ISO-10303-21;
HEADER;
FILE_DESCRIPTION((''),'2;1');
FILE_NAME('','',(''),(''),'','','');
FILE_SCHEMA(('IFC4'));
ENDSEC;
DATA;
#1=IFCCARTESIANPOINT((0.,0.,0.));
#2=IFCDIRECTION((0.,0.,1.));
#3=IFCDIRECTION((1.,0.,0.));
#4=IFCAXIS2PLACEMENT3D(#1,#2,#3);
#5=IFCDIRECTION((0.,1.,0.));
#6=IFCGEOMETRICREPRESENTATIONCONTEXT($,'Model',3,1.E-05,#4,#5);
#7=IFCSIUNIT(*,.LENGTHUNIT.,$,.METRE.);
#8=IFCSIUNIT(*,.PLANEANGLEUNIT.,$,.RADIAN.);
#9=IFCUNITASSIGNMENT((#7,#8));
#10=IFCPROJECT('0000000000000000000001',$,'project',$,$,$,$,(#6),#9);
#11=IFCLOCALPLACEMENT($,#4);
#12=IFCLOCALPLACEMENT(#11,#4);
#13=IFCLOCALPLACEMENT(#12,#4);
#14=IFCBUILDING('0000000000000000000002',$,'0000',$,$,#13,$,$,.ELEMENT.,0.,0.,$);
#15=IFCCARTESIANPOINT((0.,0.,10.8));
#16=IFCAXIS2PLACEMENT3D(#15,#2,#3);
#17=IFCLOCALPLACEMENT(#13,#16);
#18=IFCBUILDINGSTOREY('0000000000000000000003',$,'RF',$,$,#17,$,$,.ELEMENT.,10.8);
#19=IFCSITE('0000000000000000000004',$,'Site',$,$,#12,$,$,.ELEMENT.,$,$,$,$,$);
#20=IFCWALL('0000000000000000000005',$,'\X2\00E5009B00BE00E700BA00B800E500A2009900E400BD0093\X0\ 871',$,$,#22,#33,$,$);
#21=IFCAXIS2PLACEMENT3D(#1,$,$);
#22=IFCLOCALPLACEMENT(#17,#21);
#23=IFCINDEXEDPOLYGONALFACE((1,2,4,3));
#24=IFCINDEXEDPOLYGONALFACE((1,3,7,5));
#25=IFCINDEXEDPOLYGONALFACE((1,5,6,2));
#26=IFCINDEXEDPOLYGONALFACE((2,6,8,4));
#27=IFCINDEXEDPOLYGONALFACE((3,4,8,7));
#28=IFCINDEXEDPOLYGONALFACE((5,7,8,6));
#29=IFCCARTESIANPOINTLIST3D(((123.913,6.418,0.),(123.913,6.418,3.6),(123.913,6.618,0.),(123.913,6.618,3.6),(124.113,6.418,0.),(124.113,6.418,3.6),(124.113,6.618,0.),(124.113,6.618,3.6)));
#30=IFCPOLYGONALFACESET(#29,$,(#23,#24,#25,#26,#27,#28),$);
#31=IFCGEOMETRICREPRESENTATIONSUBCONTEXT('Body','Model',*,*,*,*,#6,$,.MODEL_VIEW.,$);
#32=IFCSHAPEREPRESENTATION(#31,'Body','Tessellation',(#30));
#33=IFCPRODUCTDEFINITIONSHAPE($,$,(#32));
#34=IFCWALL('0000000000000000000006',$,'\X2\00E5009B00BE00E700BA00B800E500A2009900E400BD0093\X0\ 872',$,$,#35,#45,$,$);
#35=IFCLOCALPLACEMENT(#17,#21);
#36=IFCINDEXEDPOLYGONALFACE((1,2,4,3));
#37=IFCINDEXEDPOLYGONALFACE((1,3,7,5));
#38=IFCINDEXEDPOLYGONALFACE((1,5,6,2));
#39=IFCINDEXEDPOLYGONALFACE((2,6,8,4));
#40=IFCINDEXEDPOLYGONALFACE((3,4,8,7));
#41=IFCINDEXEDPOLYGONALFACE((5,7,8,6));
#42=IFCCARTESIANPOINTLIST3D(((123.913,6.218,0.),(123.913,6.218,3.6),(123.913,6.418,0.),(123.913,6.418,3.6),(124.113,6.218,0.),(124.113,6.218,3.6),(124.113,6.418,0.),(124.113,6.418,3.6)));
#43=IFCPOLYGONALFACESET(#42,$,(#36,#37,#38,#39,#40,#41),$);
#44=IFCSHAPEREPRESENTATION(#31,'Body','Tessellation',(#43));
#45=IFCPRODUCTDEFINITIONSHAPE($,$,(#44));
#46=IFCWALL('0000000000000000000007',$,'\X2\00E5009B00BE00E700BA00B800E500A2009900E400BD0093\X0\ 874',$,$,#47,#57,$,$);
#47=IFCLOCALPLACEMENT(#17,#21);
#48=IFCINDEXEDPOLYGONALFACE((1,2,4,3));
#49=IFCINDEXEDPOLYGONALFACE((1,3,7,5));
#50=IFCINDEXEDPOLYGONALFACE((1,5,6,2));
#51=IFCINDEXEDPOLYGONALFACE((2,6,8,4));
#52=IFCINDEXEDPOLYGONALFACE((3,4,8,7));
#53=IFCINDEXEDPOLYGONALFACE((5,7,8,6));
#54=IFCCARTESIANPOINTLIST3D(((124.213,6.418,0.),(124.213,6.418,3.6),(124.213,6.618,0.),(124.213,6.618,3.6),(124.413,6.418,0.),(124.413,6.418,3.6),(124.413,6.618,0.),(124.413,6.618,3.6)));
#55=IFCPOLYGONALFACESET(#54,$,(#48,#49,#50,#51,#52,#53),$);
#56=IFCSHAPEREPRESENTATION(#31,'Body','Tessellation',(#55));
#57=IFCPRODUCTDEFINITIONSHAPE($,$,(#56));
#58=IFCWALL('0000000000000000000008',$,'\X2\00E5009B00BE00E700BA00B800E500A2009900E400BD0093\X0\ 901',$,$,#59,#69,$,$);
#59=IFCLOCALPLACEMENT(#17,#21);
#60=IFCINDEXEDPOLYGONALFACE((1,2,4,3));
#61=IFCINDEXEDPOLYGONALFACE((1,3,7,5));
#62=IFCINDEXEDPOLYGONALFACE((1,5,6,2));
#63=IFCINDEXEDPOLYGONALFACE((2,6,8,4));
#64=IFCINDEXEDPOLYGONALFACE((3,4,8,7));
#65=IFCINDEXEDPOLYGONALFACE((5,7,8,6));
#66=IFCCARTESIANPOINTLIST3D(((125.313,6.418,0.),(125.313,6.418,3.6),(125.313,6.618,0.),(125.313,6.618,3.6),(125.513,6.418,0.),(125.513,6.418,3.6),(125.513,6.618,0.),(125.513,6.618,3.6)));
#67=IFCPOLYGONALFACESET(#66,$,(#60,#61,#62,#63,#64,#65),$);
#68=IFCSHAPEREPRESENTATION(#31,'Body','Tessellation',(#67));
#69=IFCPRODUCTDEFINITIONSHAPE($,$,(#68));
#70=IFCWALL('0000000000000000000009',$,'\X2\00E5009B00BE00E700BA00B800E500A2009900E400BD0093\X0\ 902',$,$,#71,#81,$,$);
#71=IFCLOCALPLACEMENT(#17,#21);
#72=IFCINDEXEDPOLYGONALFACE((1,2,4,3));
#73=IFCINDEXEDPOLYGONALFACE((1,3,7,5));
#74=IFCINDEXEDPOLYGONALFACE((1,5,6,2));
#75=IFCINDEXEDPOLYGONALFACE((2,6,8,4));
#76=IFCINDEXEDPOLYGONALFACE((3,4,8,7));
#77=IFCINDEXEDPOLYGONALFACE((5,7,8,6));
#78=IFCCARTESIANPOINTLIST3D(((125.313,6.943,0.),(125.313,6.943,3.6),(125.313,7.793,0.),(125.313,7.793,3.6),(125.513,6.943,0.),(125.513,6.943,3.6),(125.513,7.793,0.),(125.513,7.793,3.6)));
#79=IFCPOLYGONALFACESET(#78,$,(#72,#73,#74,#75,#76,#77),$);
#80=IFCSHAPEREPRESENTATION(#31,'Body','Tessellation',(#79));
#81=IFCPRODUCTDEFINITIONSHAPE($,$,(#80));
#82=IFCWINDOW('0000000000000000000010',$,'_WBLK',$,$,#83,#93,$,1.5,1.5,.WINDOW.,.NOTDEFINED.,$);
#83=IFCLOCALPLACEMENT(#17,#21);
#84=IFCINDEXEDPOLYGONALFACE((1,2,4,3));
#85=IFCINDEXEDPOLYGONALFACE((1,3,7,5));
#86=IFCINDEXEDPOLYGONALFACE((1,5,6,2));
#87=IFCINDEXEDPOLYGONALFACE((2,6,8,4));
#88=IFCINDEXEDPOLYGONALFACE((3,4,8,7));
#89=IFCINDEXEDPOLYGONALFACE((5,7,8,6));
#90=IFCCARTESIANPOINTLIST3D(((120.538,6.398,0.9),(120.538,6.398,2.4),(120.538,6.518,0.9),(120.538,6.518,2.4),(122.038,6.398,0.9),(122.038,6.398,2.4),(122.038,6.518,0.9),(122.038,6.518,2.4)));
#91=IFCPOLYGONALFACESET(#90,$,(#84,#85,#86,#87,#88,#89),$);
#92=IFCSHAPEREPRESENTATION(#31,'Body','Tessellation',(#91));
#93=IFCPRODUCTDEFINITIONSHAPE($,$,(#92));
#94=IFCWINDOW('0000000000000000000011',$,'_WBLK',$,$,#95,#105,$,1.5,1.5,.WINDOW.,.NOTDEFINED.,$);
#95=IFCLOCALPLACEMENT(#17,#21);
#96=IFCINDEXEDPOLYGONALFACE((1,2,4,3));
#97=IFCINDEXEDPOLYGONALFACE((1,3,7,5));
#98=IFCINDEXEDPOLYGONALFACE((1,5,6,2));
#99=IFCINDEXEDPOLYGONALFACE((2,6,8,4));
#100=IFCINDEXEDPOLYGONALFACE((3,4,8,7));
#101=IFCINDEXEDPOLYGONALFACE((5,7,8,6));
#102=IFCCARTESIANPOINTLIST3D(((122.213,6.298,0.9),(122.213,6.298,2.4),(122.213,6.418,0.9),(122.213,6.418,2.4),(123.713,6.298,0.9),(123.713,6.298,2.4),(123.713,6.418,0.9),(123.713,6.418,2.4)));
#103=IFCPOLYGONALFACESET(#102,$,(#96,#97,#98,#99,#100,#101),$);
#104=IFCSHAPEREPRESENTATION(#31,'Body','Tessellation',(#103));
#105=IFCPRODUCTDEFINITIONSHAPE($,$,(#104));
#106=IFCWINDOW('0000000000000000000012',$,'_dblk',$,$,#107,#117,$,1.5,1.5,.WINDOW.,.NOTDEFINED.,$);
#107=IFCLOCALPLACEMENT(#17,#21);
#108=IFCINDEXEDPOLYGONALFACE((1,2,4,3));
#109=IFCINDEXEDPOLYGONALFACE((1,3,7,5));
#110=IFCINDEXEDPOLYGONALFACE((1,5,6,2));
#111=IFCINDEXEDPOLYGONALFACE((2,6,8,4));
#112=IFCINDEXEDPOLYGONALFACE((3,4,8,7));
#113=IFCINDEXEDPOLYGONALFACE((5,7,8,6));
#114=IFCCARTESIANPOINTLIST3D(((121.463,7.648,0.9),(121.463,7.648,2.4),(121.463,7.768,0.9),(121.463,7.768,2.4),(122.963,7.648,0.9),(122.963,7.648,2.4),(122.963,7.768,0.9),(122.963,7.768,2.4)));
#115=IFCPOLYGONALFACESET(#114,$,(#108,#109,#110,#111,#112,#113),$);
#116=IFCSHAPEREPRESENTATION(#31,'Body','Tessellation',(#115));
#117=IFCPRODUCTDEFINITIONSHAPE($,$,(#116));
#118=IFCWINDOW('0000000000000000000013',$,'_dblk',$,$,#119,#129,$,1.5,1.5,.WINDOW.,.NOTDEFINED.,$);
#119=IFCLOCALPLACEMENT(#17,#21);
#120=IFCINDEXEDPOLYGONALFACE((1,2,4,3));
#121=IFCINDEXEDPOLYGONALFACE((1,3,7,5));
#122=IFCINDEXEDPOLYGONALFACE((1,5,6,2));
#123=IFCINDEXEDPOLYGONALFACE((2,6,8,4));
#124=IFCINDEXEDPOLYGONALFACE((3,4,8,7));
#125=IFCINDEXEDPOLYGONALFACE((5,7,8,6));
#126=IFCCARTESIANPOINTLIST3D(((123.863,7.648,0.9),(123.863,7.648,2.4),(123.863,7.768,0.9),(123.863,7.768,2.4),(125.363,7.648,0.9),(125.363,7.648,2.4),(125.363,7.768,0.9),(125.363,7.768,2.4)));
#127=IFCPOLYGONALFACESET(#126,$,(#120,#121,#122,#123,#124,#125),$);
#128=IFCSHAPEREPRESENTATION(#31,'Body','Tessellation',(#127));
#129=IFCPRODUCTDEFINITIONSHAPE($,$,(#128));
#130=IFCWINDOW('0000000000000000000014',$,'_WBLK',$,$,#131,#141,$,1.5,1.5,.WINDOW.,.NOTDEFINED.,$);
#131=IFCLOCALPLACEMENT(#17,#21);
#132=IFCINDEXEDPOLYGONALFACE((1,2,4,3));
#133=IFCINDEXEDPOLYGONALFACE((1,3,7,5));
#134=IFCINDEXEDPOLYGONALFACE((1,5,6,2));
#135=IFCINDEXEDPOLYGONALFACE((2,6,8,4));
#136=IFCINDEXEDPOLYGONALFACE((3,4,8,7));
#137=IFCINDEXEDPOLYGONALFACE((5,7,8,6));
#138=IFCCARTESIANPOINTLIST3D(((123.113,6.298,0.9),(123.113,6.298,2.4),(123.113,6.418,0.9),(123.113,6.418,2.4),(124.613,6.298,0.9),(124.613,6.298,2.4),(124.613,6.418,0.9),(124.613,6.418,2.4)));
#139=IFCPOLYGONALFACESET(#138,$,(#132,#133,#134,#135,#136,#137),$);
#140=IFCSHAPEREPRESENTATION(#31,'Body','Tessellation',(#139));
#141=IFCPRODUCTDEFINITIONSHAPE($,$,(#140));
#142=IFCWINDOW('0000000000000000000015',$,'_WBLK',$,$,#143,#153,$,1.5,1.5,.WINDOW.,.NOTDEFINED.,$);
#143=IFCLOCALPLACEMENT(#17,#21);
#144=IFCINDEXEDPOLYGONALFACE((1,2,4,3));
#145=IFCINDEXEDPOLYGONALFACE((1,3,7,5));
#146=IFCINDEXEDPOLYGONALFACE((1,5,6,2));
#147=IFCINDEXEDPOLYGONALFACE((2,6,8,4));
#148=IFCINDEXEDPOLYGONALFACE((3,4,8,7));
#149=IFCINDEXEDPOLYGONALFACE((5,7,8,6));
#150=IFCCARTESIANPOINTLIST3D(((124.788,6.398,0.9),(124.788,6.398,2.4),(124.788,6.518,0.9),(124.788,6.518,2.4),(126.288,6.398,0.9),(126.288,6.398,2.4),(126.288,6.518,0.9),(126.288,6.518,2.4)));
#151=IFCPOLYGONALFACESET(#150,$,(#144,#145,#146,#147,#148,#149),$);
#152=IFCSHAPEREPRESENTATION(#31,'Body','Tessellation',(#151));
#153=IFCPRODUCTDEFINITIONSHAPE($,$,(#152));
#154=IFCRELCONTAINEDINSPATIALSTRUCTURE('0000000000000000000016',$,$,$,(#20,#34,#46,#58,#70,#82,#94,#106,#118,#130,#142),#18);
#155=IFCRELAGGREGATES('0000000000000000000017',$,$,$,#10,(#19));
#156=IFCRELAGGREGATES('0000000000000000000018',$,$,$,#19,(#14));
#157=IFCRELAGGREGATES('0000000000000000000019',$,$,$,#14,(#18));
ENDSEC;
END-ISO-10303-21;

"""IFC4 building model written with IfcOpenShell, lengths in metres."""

from ifc_helpers import new_model, si_unit, direction, frame, frame_2d, origin_with_axes, place, context, subcontext, project, spatial, rectangle, extrude, element, save


model = new_model("IFC4")

# Units and contexts
model_context = context("Model", 3, precision=1e-05, world=origin_with_axes(), true_north=direction((0.0, 1.0, 0.0)))
body_context = subcontext(model_context, "Body", "Model", "MODEL_VIEW")
ifc_project = project(units=[si_unit("LENGTHUNIT", "METRE"), si_unit("PLANEANGLEUNIT", "RADIAN")], contexts=[model_context])

# Site, building, storey
placement = place(None, origin_with_axes())
site_placement = place(placement, origin_with_axes())
site = spatial("IfcSite", under=ifc_project, at=site_placement, Name="Site", CompositionType="ELEMENT")
building_placement = place(site_placement, origin_with_axes())
building = spatial("IfcBuilding", under=site, at=building_placement, Name="0000", CompositionType="ELEMENT", ElevationOfRefHeight=0.0, ElevationOfTerrain=0.0)
storey_placement = place(building_placement, frame((0.0, 0.0, 10.8), z_axis=(0.0, 0.0, 1.0), x_axis=(1.0, 0.0, 0.0)))
storey = spatial("IfcBuildingStorey", under=building, at=storey_placement, Name="RF", CompositionType="ELEMENT", Elevation=10.8)

# Walls
for number, where, z_axis, x_axis, name in (
    (1, (124.013, 6.518, 0.0), (0.0, 0.0, 1.0), (1.0, 0.0, 0.0), "å\u009b¾çº¸å¢\u0099ä½\u0093 871"),
    (2, (124.013, 6.318, 0.0), (0.0, 0.0, 1.0), (1.0, 0.0, 0.0), "å\u009b¾çº¸å¢\u0099ä½\u0093 872"),
    (3, (124.313, 6.518, 0.0), (0.0, 0.0, 1.0), (-1.0, 0.0, 0.0), "å\u009b¾çº¸å¢\u0099ä½\u0093 874"),
    (4, (125.413, 6.518, 0.0), (0.0, 0.0, 1.0), (0.0, -1.0, 0.0), "å\u009b¾çº¸å¢\u0099ä½\u0093 901"),
):
    element("IfcWall", number, at=place(storey_placement, frame(where, z_axis=z_axis, x_axis=x_axis)), inside=storey, Name=name, context=body_context, shape_type="SweptSolid", body=[
        extrude(rectangle(XDim=0.2, YDim=0.2, at=frame_2d((0.0, 0.0), x_axis=(1.0, 0.0, 0.0))), frame((0.0, 0.0, 0.0), z_axis=(0.0, 0.0, 1.0)), (0.0, 0.0, 1.0), 3.6),
    ])
wall_1_placement = place(storey_placement, frame((125.413, 7.368, 0.0), z_axis=(0.0, 0.0, 1.0), x_axis=(0.0, -1.0, 0.0)))
element("IfcWall", 5, at=wall_1_placement, inside=storey, Name="å\u009b¾çº¸å¢\u0099ä½\u0093 902", context=body_context, shape_type="SweptSolid", body=[
    extrude(rectangle(XDim=0.85, YDim=0.2, at=frame_2d((0.0, 0.0), x_axis=(1.0, 0.0, 0.0))), frame((0.0, 0.0, 0.0), z_axis=(0.0, 0.0, 1.0)), (0.0, 0.0, 1.0), 3.6),
])

# Windows
for number, where, z_axis, x_axis, name in (
    (6, (121.288, 6.458, 0.9), (0.0, 0.0, 1.0), (1.0, 0.0, 0.0), "_WBLK"),
    (7, (122.963, 6.358, 0.9), (0.0, 0.0, 1.0), (1.0, 0.0, 0.0), "_WBLK"),
    (8, (122.213, 7.708, 0.9), (0.0, 0.0, 1.0), (1.0, 0.0, 0.0), "_dblk"),
    (9, (124.613, 7.708, 0.9), (0.0, 0.0, 1.0), (1.0, 0.0, 0.0), "_dblk"),
    (10, (123.863, 6.358, 0.9), (0.0, 0.0, 1.0), (1.0, 0.0, 0.0), "_WBLK"),
    (11, (125.538, 6.458, 0.9), (0.0, 0.0, 1.0), (1.0, 0.0, 0.0), "_WBLK"),
):
    element("IfcWindow", number, at=place(storey_placement, frame(where, z_axis=z_axis, x_axis=x_axis)), inside=storey, Name=name, OverallHeight=1.5, OverallWidth=1.5, PartitioningType="NOTDEFINED", PredefinedType="WINDOW", context=body_context, shape_type="SweptSolid", body=[
        extrude(rectangle(XDim=1.5, YDim=0.12, at=frame_2d((0.0, 0.0), x_axis=(1.0, 0.0, 0.0))), frame((0.0, 0.0, 0.0), z_axis=(0.0, 0.0, 1.0)), (0.0, 0.0, 1.0), 1.5),
    ])

save(model, "model.ifc")
